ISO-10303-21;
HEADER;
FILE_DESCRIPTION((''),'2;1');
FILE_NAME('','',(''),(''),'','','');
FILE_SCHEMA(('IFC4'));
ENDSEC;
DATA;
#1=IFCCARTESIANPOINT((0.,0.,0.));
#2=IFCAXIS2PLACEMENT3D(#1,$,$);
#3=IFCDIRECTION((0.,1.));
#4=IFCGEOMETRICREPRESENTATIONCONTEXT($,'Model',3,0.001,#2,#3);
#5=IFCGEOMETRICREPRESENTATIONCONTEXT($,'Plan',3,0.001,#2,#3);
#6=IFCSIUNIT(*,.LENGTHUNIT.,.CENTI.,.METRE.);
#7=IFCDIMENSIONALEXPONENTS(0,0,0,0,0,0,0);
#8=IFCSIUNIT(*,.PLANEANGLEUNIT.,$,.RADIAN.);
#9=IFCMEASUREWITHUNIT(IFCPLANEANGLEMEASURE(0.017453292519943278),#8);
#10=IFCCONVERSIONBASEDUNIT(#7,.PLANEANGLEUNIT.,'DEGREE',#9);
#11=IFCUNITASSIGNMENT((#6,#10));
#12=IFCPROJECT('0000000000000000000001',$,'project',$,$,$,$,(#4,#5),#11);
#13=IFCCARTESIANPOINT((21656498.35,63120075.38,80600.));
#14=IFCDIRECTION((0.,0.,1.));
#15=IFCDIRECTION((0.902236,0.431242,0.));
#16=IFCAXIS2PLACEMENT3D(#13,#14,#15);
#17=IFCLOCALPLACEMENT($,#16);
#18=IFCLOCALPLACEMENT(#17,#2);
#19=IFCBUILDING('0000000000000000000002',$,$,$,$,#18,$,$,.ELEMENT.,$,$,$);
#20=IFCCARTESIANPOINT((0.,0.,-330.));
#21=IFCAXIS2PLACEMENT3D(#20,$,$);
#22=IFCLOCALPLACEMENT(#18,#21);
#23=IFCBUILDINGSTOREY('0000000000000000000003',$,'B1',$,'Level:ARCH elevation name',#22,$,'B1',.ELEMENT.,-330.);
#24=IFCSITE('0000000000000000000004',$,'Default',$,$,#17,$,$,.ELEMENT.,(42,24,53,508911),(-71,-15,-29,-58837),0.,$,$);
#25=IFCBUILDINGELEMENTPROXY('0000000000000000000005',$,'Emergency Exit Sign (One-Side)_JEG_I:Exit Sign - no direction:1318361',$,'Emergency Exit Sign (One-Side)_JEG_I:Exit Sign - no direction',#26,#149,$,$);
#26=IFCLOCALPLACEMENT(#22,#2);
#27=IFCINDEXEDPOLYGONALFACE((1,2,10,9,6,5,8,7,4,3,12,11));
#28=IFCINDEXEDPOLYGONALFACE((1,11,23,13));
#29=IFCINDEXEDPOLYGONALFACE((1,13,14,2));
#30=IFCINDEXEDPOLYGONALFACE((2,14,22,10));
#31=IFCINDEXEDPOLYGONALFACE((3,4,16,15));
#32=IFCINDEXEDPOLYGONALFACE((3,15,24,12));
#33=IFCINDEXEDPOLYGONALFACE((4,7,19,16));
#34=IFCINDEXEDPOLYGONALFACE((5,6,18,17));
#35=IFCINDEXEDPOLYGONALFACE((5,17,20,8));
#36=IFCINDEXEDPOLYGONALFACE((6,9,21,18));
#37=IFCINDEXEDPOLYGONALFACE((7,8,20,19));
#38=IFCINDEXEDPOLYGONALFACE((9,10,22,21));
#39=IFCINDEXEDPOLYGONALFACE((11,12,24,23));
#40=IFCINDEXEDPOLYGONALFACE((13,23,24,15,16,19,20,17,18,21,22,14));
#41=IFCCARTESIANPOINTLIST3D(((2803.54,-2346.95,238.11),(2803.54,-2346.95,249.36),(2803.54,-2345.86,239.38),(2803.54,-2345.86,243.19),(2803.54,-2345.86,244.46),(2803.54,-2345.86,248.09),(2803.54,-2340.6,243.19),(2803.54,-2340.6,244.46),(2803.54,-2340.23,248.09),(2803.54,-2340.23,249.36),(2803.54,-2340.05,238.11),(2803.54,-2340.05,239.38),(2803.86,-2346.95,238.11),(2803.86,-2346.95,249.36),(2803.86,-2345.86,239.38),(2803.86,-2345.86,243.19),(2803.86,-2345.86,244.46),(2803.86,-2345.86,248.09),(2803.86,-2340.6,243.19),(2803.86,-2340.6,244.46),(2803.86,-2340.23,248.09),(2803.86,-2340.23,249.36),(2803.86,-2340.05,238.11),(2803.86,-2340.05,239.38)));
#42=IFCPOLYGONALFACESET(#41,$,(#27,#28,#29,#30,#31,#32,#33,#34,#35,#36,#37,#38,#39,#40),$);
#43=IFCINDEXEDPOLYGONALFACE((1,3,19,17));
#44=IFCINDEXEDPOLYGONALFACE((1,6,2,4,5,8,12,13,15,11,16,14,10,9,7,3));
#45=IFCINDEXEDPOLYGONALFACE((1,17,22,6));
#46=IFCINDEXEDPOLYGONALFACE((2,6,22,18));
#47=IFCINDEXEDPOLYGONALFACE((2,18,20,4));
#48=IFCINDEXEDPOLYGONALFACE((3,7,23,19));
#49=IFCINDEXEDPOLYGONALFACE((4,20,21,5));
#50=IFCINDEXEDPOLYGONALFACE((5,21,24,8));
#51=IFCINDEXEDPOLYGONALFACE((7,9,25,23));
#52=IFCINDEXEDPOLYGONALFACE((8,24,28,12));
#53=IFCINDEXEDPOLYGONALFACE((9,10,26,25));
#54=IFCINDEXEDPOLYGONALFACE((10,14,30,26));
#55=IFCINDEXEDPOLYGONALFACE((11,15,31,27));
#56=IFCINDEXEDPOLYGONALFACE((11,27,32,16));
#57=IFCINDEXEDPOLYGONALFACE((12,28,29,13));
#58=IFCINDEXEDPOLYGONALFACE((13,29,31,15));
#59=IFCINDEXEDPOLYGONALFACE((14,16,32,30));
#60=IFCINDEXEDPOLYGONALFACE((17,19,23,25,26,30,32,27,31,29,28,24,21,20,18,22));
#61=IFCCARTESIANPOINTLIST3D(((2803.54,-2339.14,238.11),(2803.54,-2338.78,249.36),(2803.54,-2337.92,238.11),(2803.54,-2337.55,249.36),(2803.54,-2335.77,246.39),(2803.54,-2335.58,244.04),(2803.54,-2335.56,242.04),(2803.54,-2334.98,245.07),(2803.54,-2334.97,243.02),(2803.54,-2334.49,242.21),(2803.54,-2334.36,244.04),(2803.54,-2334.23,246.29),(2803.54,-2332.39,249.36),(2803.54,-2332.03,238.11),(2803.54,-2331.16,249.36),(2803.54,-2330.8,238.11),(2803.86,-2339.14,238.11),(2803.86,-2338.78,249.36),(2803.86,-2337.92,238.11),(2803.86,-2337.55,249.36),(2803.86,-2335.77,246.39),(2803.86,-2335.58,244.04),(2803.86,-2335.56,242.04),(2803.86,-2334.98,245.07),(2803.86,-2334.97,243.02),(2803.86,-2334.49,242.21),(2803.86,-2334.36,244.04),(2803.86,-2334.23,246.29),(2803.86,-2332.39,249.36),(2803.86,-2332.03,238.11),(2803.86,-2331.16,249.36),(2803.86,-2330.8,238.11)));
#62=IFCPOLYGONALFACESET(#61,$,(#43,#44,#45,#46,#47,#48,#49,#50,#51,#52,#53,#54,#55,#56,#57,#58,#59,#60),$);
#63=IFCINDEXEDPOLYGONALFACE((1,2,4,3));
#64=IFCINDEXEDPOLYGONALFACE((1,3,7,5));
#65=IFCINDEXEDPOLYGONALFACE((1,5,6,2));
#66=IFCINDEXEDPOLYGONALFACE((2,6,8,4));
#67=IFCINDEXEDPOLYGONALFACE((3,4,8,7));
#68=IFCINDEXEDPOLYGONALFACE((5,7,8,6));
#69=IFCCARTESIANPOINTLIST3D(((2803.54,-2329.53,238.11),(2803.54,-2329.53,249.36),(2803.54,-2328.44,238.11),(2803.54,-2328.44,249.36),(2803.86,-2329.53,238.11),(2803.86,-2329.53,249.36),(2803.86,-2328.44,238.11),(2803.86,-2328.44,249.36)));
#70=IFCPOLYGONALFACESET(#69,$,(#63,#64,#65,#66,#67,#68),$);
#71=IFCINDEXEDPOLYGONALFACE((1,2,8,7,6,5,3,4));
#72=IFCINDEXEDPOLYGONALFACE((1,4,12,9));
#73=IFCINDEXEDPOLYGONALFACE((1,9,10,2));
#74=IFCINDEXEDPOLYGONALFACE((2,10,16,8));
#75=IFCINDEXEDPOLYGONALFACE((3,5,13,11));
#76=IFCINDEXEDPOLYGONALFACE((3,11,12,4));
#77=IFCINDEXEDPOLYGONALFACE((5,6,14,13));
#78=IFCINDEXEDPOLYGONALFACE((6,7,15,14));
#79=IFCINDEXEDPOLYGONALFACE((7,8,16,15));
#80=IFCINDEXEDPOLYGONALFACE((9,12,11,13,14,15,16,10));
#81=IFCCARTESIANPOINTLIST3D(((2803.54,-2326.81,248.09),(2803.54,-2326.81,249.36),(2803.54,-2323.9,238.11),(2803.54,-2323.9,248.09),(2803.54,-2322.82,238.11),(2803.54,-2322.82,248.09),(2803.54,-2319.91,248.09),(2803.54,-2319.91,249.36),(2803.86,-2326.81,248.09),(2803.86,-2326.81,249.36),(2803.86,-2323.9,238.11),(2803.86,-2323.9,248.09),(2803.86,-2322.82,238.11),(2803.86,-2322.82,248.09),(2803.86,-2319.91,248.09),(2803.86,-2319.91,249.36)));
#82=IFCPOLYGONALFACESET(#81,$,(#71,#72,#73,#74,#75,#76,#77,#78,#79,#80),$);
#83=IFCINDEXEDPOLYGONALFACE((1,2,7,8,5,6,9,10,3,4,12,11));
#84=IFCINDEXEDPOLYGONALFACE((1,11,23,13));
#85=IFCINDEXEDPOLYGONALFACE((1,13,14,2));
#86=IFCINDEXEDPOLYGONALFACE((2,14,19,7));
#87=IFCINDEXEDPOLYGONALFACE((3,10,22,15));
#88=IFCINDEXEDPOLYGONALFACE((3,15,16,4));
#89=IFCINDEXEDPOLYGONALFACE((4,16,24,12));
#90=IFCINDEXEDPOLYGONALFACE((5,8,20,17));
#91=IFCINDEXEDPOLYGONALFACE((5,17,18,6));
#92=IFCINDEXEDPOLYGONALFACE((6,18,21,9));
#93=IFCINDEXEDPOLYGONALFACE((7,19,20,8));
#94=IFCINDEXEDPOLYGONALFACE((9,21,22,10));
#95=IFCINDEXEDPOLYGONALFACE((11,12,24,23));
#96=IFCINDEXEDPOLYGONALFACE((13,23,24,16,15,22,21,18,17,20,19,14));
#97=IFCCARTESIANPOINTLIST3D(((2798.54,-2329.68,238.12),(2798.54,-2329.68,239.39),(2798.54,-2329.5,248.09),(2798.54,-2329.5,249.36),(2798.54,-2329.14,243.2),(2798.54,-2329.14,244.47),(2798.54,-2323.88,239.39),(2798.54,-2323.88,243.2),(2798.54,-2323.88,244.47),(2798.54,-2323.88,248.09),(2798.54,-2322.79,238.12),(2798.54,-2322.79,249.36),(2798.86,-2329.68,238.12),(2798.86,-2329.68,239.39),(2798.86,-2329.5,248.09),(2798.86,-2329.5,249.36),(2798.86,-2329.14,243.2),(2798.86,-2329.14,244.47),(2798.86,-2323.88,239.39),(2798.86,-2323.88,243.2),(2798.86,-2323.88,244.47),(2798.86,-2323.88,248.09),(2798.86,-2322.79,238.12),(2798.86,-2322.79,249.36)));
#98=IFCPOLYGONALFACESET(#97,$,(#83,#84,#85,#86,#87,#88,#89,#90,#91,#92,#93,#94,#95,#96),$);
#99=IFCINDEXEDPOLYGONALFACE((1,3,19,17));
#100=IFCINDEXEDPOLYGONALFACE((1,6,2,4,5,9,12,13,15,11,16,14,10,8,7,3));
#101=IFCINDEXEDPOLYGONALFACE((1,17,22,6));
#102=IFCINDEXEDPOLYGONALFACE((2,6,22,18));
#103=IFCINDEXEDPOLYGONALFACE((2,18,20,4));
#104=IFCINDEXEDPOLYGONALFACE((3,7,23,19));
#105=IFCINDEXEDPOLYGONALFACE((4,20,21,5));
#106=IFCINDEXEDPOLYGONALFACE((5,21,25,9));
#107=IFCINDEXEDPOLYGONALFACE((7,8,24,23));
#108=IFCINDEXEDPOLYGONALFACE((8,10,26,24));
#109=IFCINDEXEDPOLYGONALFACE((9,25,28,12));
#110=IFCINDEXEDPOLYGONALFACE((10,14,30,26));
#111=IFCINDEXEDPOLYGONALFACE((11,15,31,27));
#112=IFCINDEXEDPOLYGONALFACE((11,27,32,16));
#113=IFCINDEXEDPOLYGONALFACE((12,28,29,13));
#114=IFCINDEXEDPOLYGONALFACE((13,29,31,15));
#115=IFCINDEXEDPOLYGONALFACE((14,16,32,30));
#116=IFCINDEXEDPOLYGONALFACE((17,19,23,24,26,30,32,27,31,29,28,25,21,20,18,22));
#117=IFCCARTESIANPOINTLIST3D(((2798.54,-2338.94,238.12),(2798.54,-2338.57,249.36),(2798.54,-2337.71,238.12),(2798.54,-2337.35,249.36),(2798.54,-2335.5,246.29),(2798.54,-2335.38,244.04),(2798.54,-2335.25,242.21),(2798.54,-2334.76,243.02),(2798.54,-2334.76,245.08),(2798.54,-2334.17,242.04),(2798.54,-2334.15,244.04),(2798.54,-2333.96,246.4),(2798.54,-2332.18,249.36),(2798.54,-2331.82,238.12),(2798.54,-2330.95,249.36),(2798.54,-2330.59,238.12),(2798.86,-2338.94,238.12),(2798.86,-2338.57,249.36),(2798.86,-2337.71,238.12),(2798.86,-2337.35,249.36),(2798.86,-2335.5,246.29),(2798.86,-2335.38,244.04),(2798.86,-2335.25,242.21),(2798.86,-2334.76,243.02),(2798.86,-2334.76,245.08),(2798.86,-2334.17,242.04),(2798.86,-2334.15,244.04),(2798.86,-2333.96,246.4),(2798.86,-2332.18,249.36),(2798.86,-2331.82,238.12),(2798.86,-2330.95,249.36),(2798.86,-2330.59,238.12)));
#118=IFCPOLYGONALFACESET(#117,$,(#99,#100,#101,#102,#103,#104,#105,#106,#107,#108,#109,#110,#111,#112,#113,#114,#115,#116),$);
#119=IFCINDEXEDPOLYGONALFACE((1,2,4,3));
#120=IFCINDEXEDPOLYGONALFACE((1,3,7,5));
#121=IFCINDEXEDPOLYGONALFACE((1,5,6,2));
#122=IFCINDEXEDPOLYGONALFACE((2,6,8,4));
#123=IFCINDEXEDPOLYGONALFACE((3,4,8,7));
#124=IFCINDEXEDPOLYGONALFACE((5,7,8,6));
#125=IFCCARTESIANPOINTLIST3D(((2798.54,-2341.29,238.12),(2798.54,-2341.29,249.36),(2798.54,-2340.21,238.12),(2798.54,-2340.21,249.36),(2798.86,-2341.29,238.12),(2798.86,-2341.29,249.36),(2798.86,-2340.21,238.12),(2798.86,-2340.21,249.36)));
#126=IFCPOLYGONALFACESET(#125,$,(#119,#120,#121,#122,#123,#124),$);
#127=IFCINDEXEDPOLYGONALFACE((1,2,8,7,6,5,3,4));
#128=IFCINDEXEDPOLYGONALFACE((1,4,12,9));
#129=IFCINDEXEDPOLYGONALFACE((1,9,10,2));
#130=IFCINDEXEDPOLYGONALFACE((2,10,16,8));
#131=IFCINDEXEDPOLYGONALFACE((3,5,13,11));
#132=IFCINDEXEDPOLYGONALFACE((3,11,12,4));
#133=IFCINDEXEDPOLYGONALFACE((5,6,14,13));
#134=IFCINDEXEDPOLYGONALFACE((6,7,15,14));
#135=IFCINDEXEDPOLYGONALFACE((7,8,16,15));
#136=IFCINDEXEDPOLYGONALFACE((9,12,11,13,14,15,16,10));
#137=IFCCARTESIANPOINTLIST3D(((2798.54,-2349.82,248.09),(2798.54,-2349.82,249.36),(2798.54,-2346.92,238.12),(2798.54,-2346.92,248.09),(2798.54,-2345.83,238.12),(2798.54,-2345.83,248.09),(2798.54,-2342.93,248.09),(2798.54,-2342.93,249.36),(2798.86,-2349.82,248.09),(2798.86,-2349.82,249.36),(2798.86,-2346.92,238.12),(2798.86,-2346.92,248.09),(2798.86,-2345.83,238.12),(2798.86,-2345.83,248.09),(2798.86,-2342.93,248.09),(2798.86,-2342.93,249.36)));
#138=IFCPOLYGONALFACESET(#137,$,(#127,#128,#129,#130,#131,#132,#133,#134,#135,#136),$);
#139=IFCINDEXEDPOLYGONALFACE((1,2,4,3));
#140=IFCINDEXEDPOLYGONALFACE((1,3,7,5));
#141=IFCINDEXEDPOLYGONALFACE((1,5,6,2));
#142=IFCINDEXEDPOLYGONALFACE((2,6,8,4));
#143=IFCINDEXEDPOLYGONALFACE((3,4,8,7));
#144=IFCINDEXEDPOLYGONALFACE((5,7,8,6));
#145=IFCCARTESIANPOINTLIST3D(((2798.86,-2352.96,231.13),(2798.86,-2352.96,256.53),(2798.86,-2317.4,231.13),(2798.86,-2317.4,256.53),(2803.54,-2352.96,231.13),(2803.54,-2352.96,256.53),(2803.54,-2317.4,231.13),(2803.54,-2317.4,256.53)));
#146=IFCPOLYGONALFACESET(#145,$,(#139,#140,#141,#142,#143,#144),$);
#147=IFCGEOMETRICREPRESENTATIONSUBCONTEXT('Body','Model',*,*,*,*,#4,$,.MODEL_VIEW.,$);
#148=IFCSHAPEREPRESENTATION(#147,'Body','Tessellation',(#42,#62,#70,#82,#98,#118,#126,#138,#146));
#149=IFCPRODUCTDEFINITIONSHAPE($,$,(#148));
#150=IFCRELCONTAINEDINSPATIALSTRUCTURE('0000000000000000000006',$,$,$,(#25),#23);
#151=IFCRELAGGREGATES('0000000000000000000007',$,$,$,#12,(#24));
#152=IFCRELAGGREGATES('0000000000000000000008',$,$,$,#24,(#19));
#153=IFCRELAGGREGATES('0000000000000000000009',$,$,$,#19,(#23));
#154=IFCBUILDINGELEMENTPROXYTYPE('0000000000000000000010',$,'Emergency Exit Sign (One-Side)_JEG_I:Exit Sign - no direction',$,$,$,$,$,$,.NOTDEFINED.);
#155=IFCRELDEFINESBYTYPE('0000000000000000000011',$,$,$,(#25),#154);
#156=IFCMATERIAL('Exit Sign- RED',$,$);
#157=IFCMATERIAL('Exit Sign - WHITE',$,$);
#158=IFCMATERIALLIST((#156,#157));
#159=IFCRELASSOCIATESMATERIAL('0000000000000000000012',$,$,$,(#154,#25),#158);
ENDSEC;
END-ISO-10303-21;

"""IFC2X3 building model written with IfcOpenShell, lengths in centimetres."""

from ifc_helpers import new_model, entity, si_unit, converted_unit, direction, frame, frame_2d, origin, origin_2d_with_axis, place, context, subcontext, project, spatial, polyline, rectangle, outline, extrude, source, transform, mapped, material, material_list, type_object, type_shapes, element, save


model = new_model("IFC2X3")

# Units and contexts
model_context = context("Model", 3, precision=0.001, world=origin(), true_north=direction((0.0, 1.0)))
plan_context = context("Plan", 3, precision=0.001, world=origin(), true_north=direction((0.0, 1.0)))
body_context = subcontext(model_context, "Body", "Model", "MODEL_VIEW")
ifc_project = project(units=[si_unit("LENGTHUNIT", "METRE", prefix="CENTI"), converted_unit("PLANEANGLEUNIT", "DEGREE", entity("IfcPlaneAngleMeasure", 0.017453292519943278), si_unit("PLANEANGLEUNIT", "RADIAN"), dimensions=[0, 0, 0, 0, 0, 0, 0])], contexts=[model_context, plan_context])

# Site, building, storey
site_placement = place(None, frame((21656498.35, 63120075.38, 80600.0), z_axis=(0.0, 0.0, 1.0), x_axis=(0.902236, 0.431242, 0.0)))
site = spatial("IfcSite", under=ifc_project, at=site_placement, Name="Default", CompositionType="ELEMENT", RefLatitude=(42, 24, 53, 508911), RefLongitude=(-71, -15, -29, -58837), RefElevation=0.0)
building_placement = place(site_placement, origin())
building = spatial("IfcBuilding", under=site, at=building_placement, CompositionType="ELEMENT")
storey_placement = place(building_placement, frame((0.0, 0.0, -330.0)))
storey = spatial("IfcBuildingStorey", under=building, at=storey_placement, Name="B1", ObjectType="Level:ARCH elevation name", LongName="B1", CompositionType="ELEMENT", Elevation=-330.0)

# Shared definitions
ifc_material_1 = material(Name="Exit Sign - WHITE")
ifc_material_2 = material(Name="Exit Sign- RED")

# Building element proxy
ifc_material_list_1 = material_list([ifc_material_2, ifc_material_1])
building_element_proxy_type_1 = type_object("IfcBuildingElementProxyType", Name="Emergency Exit Sign (One-Side)_JEG_I:Exit Sign - no direction", PredefinedType="NOTDEFINED", material=ifc_material_list_1)
shared_shape_1 = source(origin(), body_context, "Body", "SweptSolid", [
    extrude(outline(polyline([(-5.65, -3.69), (5.59, -3.69), (5.59, 3.02), (4.32, 3.02), (4.32, -2.6), (0.7, -2.6), (0.7, 2.66), (-0.57, 2.66), (-0.57, -2.6), (-4.38, -2.6), (-4.38, 3.21), (-5.65, 3.21), (-5.65, -3.69)])), frame((-8.08, -5.22, 12.64), z_axis=(0.0, 1.0, 0.0), x_axis=(0.0, 0.0, 1.0)), (0.0, 0.0, 1.0), 0.32),
    extrude(outline(polyline([(-7.14, 0.57), (-6.5, -0.49), (-1.93, -0.48), (-0.78, -0.48), (-1.23, -1.32), (-3.47, -5.53), (-2.84, -6.59), (0.41, -0.48), (6.62, -0.48), (5.99, 0.57), (2.4, 0.57), (0.98, 0.58), (1.7, 1.94), (3.32, 5.0), (2.69, 6.05), (-0.22, 0.57), (-7.14, 0.57)])), frame((0.2, -5.22, 12.81), z_axis=(0.0, -1.0, 0.0), x_axis=(0.515099, 0.0, 0.857131)), (0.0, 0.0, -1.0), 0.32),
    extrude(rectangle(XDim=0.32, YDim=1.09, at=frame_2d((0.0, 0.0), x_axis=(1.0, 0.0))), frame((6.19, -5.06, 6.99), z_axis=(0.0, 0.0, 1.0), x_axis=(0.0, 1.0, 0.0)), (0.0, 0.0, 1.0), 11.25),
    extrude(outline(polyline([(-7.8, 0.54), (-7.8, -0.54), (2.18, -0.54), (2.18, -3.45), (3.45, -3.45), (3.45, 3.45), (2.18, 3.45), (2.18, 0.54), (-7.8, 0.54)])), frame((11.82, -5.22, 14.79), z_axis=(0.0, -1.0, 0.0), x_axis=(0.0, 0.0, 1.0)), (0.0, 0.0, -1.0), 0.32),
    extrude(outline(polyline([(-3.69, -5.65), (3.21, -5.65), (3.21, -4.38), (-2.6, -4.38), (-2.6, -0.57), (2.66, -0.57), (2.66, 0.7), (-2.6, 0.7), (-2.6, 4.32), (3.02, 4.32), (3.02, 5.59), (-3.69, 5.59), (-3.69, -5.65)])), frame((8.7, -0.22, 12.65), z_axis=(0.0, 1.0, 0.0), x_axis=(-1.0, 0.0, 0.0)), (0.0, 0.0, 1.0), 0.32),
    extrude(outline(polyline([(-4.16, -5.82), (-2.93, -5.82), (-0.58, -1.9), (0.01, -0.92), (0.5, -1.73), (2.96, -5.82), (4.18, -5.82), (0.62, 0.1), (3.82, 5.42), (2.59, 5.42), (0.75, 2.35), (0.01, 1.14), (-0.79, 2.46), (-2.57, 5.42), (-3.8, 5.42), (-0.6, 0.1), (-4.16, -5.82)])), frame((0.43, -0.22, 12.82), z_axis=(0.0, 1.0, 0.0), x_axis=(-1.0, 0.0, 0.0)), (0.0, 0.0, 1.0), 0.32),
    extrude(rectangle(XDim=0.32, YDim=1.09, at=origin_2d_with_axis()), frame((-5.57, -0.06, 6.99), z_axis=(0.0, 0.0, 1.0), x_axis=(0.0, -1.0, 0.0)), (0.0, 0.0, 1.0), 11.25),
    extrude(outline(polyline([(-0.54, -7.8), (0.54, -7.8), (0.54, 2.18), (3.45, 2.18), (3.45, 3.45), (-3.45, 3.45), (-3.45, 2.18), (-0.54, 2.18), (-0.54, -7.8)])), frame((-11.2, -0.22, 14.79), z_axis=(0.0, 1.0, 0.0), x_axis=(-1.0, 0.0, 0.0)), (0.0, 0.0, 1.0), 0.32),
    extrude(rectangle(XDim=4.68, YDim=35.56, at=origin_2d_with_axis()), frame((0.0, -2.56, 0.01), z_axis=(0.0, 0.0, 1.0), x_axis=(0.0, 1.0, 0.0)), (0.0, 0.0, 1.0), 25.4),
])
type_shapes(building_element_proxy_type_1, [shared_shape_1])
for number, where, z_axis, x_axis, name in (
    (1, (2798.64, -2335.18, 231.12), (0.0, 0.0, 1.0), (0.0, 1.0, 0.0), "Emergency Exit Sign (One-Side)_JEG_I:Exit Sign - no direction:1318361"),
):
    element("IfcBuildingElementProxy", number, at=place(storey_placement, frame(where, z_axis=z_axis, x_axis=x_axis)), inside=storey, type_object=building_element_proxy_type_1, material=ifc_material_list_1, Name=name, ObjectType="Emergency Exit Sign (One-Side)_JEG_I:Exit Sign - no direction", context=body_context, shape_type="MappedRepresentation", body=[
        mapped(shared_shape_1, transform((0.0, 0.0, 0.0), scale=1.0)),
    ])

save(model, "model.ifc")
